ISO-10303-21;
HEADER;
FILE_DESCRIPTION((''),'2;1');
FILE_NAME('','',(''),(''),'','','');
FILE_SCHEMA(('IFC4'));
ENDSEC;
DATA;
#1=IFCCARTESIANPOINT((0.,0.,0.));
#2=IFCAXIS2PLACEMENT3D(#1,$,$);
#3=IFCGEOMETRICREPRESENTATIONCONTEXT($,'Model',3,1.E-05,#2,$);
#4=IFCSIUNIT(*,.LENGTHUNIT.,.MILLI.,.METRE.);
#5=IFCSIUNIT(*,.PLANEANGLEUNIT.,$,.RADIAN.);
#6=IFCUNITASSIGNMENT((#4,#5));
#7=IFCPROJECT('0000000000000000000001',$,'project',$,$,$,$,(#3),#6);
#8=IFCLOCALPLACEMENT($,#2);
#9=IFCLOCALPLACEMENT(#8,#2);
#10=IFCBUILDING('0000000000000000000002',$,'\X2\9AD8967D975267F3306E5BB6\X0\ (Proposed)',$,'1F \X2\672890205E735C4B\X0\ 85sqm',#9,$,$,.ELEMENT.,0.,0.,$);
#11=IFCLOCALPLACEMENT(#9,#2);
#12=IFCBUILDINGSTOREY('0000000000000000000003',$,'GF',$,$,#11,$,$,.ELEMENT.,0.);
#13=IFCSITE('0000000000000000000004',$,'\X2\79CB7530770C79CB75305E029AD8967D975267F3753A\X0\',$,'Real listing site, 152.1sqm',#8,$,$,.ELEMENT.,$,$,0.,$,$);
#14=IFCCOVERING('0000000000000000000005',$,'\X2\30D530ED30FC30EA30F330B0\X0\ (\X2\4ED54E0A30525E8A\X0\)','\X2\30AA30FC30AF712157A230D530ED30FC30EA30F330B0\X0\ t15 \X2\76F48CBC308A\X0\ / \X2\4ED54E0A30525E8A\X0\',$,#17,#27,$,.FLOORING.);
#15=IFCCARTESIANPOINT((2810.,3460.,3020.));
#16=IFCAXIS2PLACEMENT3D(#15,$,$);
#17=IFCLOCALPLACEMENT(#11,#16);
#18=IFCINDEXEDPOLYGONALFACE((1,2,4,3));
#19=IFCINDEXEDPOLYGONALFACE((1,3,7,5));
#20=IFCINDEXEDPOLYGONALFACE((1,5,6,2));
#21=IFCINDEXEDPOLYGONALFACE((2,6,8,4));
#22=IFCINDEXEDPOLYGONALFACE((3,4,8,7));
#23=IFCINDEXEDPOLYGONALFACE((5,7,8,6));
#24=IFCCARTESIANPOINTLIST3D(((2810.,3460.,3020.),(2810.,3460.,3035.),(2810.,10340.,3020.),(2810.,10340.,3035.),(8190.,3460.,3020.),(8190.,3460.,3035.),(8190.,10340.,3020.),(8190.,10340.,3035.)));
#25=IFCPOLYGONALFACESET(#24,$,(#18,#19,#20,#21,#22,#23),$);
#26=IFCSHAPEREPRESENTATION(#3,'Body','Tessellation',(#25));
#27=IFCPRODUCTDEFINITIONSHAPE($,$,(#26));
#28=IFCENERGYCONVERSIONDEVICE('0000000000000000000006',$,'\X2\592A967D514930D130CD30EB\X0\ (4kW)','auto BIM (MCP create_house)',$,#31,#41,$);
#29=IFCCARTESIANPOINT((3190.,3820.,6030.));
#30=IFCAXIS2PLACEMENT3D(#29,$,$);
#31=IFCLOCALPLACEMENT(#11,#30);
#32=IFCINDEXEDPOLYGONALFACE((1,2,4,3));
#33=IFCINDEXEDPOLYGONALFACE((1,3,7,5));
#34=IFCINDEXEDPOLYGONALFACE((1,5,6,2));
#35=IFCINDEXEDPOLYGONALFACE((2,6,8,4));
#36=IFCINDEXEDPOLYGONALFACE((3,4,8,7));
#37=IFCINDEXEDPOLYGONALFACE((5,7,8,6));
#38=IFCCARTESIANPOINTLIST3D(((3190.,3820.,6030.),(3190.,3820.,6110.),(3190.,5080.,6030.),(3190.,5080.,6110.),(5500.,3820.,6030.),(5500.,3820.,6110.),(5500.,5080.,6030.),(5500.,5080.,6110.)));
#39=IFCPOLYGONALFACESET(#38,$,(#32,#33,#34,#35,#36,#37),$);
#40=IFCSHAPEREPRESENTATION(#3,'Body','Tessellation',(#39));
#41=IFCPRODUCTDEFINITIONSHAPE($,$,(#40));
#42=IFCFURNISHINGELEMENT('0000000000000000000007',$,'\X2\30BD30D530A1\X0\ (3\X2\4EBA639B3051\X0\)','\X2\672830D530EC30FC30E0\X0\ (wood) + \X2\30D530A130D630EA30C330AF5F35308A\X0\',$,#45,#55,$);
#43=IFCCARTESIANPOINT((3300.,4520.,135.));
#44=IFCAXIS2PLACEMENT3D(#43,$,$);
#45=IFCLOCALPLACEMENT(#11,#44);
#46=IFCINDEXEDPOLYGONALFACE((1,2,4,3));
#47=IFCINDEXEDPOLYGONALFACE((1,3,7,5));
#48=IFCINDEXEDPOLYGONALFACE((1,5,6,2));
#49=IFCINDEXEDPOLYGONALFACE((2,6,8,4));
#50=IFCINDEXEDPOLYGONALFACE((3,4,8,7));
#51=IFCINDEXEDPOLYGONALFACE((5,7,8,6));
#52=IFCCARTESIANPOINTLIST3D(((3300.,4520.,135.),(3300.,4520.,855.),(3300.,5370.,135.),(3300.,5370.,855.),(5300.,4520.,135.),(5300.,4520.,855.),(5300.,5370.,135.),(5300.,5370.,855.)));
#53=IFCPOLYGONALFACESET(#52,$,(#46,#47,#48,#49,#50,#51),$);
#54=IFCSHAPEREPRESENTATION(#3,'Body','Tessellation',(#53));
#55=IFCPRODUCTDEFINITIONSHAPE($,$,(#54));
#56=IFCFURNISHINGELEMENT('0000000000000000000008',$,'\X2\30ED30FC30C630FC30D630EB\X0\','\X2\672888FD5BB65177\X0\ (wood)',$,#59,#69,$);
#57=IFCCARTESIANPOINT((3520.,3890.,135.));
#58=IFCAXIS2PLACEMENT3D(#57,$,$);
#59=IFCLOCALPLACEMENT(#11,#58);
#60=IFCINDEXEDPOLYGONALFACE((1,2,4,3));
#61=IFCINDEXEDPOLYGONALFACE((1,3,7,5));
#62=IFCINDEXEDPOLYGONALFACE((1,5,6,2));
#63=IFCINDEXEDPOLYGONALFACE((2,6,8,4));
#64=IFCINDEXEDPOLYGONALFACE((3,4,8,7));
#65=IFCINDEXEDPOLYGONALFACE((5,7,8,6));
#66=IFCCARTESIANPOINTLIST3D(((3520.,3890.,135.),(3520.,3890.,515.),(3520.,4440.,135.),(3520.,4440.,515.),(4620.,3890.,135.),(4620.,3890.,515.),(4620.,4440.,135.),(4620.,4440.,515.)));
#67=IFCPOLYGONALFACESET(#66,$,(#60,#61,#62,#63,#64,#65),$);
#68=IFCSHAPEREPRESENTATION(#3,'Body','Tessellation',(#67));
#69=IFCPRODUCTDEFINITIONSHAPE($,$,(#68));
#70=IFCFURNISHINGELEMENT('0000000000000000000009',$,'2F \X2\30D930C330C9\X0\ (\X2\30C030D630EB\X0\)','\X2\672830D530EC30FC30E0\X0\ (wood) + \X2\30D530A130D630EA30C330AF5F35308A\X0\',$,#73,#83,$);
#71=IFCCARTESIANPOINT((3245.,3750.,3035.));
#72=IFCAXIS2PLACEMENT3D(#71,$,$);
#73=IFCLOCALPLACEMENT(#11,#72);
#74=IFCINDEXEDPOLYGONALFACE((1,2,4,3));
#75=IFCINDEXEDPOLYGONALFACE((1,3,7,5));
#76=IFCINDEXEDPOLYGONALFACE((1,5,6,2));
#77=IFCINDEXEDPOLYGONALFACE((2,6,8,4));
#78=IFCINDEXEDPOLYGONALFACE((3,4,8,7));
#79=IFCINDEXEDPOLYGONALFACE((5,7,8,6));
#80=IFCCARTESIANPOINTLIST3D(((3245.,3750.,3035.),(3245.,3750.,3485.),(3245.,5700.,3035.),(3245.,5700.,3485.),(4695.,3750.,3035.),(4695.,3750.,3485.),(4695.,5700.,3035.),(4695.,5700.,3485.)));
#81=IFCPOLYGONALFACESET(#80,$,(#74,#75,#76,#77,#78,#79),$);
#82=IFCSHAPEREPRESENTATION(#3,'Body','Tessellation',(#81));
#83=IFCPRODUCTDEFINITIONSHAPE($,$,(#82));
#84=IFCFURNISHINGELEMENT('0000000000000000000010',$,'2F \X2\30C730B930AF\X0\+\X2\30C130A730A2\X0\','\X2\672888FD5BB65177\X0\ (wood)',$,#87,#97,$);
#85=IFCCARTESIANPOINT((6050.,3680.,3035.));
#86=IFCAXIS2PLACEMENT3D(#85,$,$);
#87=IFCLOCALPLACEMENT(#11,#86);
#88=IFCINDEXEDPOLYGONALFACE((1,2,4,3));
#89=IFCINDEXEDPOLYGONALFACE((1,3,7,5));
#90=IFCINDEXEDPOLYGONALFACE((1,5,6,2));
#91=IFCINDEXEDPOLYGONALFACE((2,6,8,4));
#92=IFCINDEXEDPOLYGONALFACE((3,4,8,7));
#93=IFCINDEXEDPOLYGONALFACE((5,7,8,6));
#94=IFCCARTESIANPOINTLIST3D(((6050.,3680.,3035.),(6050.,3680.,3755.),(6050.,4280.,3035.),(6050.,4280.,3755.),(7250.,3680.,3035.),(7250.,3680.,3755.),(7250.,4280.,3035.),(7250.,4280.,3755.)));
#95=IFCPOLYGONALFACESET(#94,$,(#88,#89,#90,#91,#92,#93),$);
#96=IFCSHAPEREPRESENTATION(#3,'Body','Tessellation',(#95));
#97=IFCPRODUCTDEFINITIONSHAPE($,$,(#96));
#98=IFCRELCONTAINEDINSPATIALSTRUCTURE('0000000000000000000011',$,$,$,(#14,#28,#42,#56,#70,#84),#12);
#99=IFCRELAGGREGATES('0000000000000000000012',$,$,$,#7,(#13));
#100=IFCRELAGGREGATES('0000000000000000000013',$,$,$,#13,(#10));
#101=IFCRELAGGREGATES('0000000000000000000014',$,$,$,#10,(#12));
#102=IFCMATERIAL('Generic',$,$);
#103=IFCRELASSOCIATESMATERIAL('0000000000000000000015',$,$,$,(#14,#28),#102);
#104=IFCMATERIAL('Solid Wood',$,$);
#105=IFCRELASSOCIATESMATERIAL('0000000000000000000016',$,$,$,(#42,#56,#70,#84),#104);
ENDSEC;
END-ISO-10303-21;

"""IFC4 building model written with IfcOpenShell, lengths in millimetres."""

from ifc_helpers import new_model, si_unit, frame, frame_2d, origin, place, context, project, spatial, rectangle, extrude, material, element, save


model = new_model("IFC4")

# Units and contexts
model_context = context("Model", 3, precision=1e-05, world=origin())
ifc_project = project(units=[si_unit("LENGTHUNIT", "METRE", prefix="MILLI"), si_unit("PLANEANGLEUNIT", "RADIAN")], contexts=[model_context])

# Site, building, storey
site_placement = place(None, origin())
site = spatial("IfcSite", under=ifc_project, at=site_placement, Name="秋田県秋田市高陽青柳町", ObjectType="Real listing site, 152.1sqm", CompositionType="ELEMENT", RefElevation=0.0)
building_placement = place(site_placement, origin())
building = spatial("IfcBuilding", under=site, at=building_placement, Name="高陽青柳の家 (Proposed)", ObjectType="1F 木造平屋 85sqm", CompositionType="ELEMENT", ElevationOfRefHeight=0.0, ElevationOfTerrain=0.0)
storey_placement = place(building_placement, origin())
storey = spatial("IfcBuildingStorey", under=building, at=storey_placement, Name="GF", CompositionType="ELEMENT", Elevation=0.0)

# Shared definitions
ifc_material_1 = material(Name="Solid Wood")

# Shared definitions
ifc_material_2 = material(Name="Generic")

# Covering
covering_placement = place(storey_placement, frame((2810.0, 3460.0, 3020.0)))
element("IfcCovering", 1, at=covering_placement, inside=storey, material=ifc_material_2, Name="フローリング (仕上げ床)", Description="オーク無垢フローリング t15 直貼り / 仕上げ床", PredefinedType="FLOORING", context=model_context, shape_type="SweptSolid", body=[
    extrude(rectangle(XDim=5380.0, YDim=6880.0, at=frame_2d((2690.0, 3440.0))), frame((2810.0, 3460.0, 3020.0)), (0.0, 0.0, 1.0), 15.0),
])

# Energy conversion device
energy_conversion_device_placement = place(storey_placement, frame((3190.0, 3820.0, 6030.0)))
element("IfcEnergyConversionDevice", 2, at=energy_conversion_device_placement, inside=storey, material=ifc_material_2, Name="太陽光パネル (4kW)", Description="auto BIM (MCP create_house)", context=model_context, shape_type="SweptSolid", body=[
    extrude(rectangle(XDim=2310.0, YDim=1260.0, at=frame_2d((1155.0, 630.0))), frame((3190.0, 3820.0, 6030.0)), (0.0, 0.0, 1.0), 80.0),
])

# Furnishing elements
furnishing_1_placement = place(storey_placement, frame((3300.0, 4520.0, 135.0)))
element("IfcFurnishingElement", 3, at=furnishing_1_placement, inside=storey, material=ifc_material_1, Name="ソファ (3人掛け)", Description="木フレーム (wood) + ファブリック張り", context=model_context, shape_type="SweptSolid", body=[
    extrude(rectangle(XDim=2000.0, YDim=850.0, at=frame_2d((1000.0, 425.0))), frame((3300.0, 4520.0, 135.0)), (0.0, 0.0, 1.0), 720.0),
])
furnishing_2_placement = place(storey_placement, frame((3520.0, 3890.0, 135.0)))
element("IfcFurnishingElement", 4, at=furnishing_2_placement, inside=storey, material=ifc_material_1, Name="ローテーブル", Description="木製家具 (wood)", context=model_context, shape_type="SweptSolid", body=[
    extrude(rectangle(XDim=1100.0, YDim=550.0, at=frame_2d((550.0, 275.0))), frame((3520.0, 3890.0, 135.0)), (0.0, 0.0, 1.0), 380.0),
])
furnishing_3_placement = place(storey_placement, frame((3245.0, 3750.0, 3035.0)))
element("IfcFurnishingElement", 5, at=furnishing_3_placement, inside=storey, material=ifc_material_1, Name="2F ベッド (ダブル)", Description="木フレーム (wood) + ファブリック張り", context=model_context, shape_type="SweptSolid", body=[
    extrude(rectangle(XDim=1450.0, YDim=1950.0, at=frame_2d((725.0, 975.0))), frame((3245.0, 3750.0, 3035.0)), (0.0, 0.0, 1.0), 450.0),
])
furnishing_4_placement = place(storey_placement, frame((6050.0, 3680.0, 3035.0)))
element("IfcFurnishingElement", 6, at=furnishing_4_placement, inside=storey, material=ifc_material_1, Name="2F デスク+チェア", Description="木製家具 (wood)", context=model_context, shape_type="SweptSolid", body=[
    extrude(rectangle(XDim=1200.0, YDim=600.0, at=frame_2d((600.0, 300.0))), frame((6050.0, 3680.0, 3035.0)), (0.0, 0.0, 1.0), 720.0),
])

save(model, "model.ifc")
